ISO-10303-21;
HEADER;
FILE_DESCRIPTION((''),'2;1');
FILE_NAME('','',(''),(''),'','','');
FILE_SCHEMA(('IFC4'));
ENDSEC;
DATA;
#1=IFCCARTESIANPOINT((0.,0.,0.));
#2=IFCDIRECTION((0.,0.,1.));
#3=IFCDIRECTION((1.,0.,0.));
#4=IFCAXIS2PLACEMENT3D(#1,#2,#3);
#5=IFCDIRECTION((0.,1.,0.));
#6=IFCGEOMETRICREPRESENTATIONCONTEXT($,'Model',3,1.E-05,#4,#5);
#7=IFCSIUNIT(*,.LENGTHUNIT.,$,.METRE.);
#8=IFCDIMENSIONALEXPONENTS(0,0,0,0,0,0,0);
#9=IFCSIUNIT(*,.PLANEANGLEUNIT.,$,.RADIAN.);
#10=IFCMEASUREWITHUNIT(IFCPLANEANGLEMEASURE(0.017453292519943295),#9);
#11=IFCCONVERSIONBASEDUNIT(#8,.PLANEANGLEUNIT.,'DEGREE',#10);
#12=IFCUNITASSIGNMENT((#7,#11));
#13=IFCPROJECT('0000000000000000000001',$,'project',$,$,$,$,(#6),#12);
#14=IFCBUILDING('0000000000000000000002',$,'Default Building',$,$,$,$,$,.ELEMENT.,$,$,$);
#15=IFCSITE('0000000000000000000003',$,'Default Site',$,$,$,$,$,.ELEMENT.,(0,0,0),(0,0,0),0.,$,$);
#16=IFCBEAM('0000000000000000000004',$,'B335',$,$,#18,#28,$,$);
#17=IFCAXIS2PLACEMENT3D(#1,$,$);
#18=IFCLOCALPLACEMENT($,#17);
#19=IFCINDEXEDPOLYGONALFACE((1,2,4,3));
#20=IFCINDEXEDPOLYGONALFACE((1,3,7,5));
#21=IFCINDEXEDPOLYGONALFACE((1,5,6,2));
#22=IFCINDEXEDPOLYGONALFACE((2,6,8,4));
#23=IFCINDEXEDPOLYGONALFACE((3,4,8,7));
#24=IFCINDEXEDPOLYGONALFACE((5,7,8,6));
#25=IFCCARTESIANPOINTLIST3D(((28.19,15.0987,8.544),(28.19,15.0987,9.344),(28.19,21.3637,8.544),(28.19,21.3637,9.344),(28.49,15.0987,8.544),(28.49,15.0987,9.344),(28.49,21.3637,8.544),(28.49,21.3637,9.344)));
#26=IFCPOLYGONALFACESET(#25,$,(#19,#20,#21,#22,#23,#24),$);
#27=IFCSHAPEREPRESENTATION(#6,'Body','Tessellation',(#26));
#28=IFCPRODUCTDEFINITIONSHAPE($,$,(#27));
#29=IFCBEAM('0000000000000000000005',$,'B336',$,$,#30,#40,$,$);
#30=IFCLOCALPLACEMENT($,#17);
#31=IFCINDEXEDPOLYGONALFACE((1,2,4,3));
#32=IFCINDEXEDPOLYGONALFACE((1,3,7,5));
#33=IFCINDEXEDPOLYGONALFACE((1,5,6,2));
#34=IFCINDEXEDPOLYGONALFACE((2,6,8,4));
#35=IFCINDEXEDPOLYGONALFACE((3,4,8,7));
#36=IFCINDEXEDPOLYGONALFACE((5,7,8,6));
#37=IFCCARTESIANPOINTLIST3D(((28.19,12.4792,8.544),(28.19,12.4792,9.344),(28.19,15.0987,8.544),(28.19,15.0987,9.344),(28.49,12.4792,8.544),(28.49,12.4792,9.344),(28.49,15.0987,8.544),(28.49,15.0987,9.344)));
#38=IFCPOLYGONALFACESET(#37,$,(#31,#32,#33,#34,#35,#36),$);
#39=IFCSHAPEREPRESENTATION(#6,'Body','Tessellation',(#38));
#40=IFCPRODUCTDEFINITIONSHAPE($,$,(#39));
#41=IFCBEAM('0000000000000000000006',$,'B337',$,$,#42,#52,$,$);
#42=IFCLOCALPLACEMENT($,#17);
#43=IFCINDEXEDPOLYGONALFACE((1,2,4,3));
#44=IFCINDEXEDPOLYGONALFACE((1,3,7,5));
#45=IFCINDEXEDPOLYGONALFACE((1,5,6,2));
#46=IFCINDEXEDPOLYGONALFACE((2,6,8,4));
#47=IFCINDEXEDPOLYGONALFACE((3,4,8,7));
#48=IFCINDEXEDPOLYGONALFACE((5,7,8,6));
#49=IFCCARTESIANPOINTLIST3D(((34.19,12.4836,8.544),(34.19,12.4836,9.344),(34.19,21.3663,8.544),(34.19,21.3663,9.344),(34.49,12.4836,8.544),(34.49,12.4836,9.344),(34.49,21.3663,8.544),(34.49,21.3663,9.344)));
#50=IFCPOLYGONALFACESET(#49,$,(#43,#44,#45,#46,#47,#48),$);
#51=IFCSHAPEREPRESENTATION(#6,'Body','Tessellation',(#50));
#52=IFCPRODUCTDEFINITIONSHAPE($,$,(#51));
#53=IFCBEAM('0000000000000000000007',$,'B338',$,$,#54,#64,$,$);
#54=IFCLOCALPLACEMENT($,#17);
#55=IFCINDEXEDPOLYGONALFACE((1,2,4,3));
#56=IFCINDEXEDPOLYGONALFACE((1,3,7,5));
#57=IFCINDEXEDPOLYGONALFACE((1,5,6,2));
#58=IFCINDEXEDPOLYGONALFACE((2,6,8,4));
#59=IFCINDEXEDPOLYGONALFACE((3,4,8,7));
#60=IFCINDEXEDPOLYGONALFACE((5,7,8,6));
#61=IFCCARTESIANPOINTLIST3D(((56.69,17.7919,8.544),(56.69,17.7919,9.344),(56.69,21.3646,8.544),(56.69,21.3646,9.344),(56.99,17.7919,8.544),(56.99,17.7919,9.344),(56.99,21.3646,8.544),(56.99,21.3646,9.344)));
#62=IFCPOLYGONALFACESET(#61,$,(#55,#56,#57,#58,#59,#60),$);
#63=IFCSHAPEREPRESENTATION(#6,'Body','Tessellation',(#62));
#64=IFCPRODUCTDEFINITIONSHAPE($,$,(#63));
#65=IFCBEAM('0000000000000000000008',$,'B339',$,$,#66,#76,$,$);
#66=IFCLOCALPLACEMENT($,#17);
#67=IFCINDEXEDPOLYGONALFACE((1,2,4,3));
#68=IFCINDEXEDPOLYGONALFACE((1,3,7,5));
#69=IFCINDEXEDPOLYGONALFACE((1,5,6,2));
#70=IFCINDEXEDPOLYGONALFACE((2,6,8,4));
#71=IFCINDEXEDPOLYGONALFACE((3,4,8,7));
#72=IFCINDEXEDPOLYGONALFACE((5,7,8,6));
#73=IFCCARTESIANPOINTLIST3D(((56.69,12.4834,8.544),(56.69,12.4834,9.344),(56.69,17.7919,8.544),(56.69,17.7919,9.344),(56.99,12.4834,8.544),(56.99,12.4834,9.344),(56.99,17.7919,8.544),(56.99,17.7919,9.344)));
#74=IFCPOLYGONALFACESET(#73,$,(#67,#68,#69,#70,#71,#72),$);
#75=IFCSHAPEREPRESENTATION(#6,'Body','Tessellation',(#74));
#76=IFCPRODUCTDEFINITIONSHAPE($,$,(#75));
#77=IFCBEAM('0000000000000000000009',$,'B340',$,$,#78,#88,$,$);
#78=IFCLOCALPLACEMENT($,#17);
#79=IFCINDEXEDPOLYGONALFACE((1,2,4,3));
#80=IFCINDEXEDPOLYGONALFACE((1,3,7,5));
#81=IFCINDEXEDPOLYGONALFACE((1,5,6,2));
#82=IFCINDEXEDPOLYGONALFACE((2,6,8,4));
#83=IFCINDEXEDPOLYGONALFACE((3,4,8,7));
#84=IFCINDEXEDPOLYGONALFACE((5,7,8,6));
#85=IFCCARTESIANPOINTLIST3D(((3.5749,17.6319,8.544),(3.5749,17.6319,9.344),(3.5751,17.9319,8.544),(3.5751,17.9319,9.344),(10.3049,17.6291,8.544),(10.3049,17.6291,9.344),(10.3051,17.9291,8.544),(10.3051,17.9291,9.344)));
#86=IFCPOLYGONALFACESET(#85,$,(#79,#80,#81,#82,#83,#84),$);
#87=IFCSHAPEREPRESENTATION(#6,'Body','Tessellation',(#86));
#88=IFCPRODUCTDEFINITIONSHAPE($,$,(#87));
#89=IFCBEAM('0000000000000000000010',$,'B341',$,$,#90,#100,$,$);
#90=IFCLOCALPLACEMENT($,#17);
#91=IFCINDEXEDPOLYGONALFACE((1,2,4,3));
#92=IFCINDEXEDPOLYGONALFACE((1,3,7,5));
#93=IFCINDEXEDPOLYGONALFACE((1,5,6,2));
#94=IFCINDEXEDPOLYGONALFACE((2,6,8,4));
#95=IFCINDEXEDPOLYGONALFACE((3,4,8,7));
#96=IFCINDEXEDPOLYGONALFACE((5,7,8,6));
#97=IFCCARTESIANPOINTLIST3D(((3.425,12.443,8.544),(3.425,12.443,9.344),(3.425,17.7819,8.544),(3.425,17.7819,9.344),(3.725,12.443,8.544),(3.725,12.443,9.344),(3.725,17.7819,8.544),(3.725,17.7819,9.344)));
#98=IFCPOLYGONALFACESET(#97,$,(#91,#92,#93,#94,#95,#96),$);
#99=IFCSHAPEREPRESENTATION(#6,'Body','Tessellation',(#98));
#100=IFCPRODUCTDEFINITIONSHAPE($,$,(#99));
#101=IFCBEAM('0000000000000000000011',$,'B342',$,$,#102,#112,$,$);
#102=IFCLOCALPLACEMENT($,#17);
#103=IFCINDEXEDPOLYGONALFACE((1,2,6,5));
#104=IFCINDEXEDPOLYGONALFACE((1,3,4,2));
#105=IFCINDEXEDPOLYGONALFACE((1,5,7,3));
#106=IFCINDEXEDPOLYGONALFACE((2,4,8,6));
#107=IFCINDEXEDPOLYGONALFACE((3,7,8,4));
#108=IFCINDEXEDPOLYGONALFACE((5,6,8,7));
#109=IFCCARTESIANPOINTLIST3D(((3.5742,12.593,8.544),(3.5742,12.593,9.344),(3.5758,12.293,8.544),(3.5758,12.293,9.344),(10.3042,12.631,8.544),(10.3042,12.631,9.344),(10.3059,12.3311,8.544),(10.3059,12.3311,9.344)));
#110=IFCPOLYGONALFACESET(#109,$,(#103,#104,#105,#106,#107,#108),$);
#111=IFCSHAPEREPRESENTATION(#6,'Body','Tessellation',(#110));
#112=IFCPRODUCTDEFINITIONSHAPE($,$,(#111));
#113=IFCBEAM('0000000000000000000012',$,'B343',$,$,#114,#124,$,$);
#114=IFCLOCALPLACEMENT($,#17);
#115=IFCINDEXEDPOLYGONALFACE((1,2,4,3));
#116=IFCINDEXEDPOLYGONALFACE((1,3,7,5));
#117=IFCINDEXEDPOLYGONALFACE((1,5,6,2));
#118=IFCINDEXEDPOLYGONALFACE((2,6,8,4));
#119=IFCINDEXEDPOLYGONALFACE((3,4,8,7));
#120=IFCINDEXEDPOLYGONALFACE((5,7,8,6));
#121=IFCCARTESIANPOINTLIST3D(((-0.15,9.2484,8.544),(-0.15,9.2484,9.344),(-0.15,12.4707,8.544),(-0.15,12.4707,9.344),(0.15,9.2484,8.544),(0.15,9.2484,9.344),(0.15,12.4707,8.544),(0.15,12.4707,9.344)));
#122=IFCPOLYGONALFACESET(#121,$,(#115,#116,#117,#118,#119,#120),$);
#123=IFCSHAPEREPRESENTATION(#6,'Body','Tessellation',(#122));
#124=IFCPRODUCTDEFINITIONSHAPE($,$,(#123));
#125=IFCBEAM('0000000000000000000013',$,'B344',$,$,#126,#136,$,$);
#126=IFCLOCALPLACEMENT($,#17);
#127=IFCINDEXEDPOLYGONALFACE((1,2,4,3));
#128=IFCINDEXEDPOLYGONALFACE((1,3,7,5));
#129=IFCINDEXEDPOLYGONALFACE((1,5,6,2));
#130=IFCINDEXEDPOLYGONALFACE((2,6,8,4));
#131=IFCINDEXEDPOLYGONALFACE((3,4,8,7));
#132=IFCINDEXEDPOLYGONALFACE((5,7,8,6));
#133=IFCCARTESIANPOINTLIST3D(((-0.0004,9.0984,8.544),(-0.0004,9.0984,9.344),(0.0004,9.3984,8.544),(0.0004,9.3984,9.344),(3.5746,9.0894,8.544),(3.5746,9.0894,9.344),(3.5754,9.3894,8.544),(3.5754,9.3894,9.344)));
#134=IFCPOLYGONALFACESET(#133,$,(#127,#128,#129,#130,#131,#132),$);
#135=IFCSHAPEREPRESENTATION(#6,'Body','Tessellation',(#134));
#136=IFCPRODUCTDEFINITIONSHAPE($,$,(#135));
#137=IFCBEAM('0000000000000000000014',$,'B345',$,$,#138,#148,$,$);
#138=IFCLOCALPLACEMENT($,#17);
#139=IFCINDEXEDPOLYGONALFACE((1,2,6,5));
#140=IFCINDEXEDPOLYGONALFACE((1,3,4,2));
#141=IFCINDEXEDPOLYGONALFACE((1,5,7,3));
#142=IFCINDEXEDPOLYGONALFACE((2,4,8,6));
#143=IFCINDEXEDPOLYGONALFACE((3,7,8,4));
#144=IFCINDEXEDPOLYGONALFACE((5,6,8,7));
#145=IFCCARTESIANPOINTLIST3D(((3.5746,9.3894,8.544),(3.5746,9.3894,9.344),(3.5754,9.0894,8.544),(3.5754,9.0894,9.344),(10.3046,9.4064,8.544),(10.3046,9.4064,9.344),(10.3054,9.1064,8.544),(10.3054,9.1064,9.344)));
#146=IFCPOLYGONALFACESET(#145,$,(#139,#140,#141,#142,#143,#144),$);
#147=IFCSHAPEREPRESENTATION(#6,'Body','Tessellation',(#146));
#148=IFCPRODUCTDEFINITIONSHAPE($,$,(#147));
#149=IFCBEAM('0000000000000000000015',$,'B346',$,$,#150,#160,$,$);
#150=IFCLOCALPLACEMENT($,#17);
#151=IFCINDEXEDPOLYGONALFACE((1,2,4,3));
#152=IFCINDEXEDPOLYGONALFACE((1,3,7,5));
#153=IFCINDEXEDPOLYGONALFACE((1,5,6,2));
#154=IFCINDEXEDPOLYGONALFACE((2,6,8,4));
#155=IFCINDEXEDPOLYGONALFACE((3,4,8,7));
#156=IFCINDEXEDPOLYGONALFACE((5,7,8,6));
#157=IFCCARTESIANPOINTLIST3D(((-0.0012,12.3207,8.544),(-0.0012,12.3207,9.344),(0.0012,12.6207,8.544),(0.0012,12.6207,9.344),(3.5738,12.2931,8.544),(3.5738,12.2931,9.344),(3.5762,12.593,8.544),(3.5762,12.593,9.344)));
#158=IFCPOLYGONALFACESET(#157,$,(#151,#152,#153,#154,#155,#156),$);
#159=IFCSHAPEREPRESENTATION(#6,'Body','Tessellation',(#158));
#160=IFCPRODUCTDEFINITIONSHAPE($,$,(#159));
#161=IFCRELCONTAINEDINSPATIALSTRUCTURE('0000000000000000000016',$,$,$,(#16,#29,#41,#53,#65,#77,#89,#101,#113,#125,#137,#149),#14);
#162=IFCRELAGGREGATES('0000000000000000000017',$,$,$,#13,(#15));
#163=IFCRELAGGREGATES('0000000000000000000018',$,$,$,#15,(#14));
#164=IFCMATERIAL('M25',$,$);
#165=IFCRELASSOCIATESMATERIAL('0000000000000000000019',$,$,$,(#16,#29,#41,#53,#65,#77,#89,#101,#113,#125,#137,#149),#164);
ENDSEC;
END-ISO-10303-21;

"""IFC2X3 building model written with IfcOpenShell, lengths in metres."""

from ifc_helpers import new_model, entity, si_unit, converted_unit, direction, frame, frame_2d, origin_with_axes, place, context, project, spatial, rectangle, extrude, material, element, save


model = new_model("IFC2X3")

# Units and contexts
model_context = context("Model", 3, precision=1e-05, world=origin_with_axes(), true_north=direction((0.0, 1.0, 0.0)))
ifc_project = project(units=[si_unit("LENGTHUNIT", "METRE"), converted_unit("PLANEANGLEUNIT", "DEGREE", entity("IfcPlaneAngleMeasure", 0.017453292519943295), si_unit("PLANEANGLEUNIT", "RADIAN"), dimensions=[0, 0, 0, 0, 0, 0, 0])], contexts=[model_context])

# Site, building
site = spatial("IfcSite", under=ifc_project, Name="Default Site", CompositionType="ELEMENT", RefLatitude=(0, 0, 0), RefLongitude=(0, 0, 0), RefElevation=0.0)
building = spatial("IfcBuilding", under=site, Name="Default Building", CompositionType="ELEMENT")

# Beams
ifc_material = material(Name="M25")
placement = place(None, origin_with_axes())
element("IfcBeam", 1, at=placement, inside=building, material=ifc_material, Name="B335", context=model_context, shape_type="SweptSolid", body=[
    extrude(rectangle(XDim=0.3, YDim=0.8, at=frame_2d((0.0, 0.0), x_axis=(0.0, 1.0, 0.0))), frame((28.34, 21.3637, 8.944), z_axis=(0.0, -1.0, 0.0), x_axis=(0.0, 0.0, -1.0)), (0.0, 0.0, 1.0), 6.265),
])
element("IfcBeam", 2, at=placement, inside=building, material=ifc_material, Name="B336", context=model_context, shape_type="SweptSolid", body=[
    extrude(rectangle(XDim=0.3, YDim=0.8, at=frame_2d((0.0, 0.0), x_axis=(0.0, 1.0, 0.0))), frame((28.34, 15.0987, 8.944), z_axis=(0.0, -1.0, 0.0), x_axis=(0.0, 0.0, -1.0)), (0.0, 0.0, 1.0), 2.6195),
])
element("IfcBeam", 3, at=placement, inside=building, material=ifc_material, Name="B337", context=model_context, shape_type="SweptSolid", body=[
    extrude(rectangle(XDim=0.3, YDim=0.8, at=frame_2d((0.0, 0.0), x_axis=(0.0, 1.0, 0.0))), frame((34.34, 12.4836, 8.944), z_axis=(0.0, 1.0, 0.0), x_axis=(0.0, 0.0, -1.0)), (0.0, 0.0, 1.0), 8.8827),
])
element("IfcBeam", 4, at=placement, inside=building, material=ifc_material, Name="B338", context=model_context, shape_type="SweptSolid", body=[
    extrude(rectangle(XDim=0.3, YDim=0.8, at=frame_2d((0.0, 0.0), x_axis=(0.0, 1.0, 0.0))), frame((56.84, 17.7919, 8.944), z_axis=(0.0, 1.0, 0.0), x_axis=(0.0, 0.0, -1.0)), (0.0, 0.0, 1.0), 3.5727),
])
element("IfcBeam", 5, at=placement, inside=building, material=ifc_material, Name="B339", context=model_context, shape_type="SweptSolid", body=[
    extrude(rectangle(XDim=0.3, YDim=0.8, at=frame_2d((0.0, 0.0), x_axis=(0.0, 1.0, 0.0))), frame((56.84, 12.4834, 8.944), z_axis=(0.0, 1.0, 0.0), x_axis=(0.0, 0.0, -1.0)), (0.0, 0.0, 1.0), 5.3085),
])
element("IfcBeam", 6, at=placement, inside=building, material=ifc_material, Name="B340", context=model_context, shape_type="SweptSolid", body=[
    extrude(rectangle(XDim=0.3, YDim=0.8, at=frame_2d((0.0, 0.0), x_axis=(0.0, 1.0, 0.0))), frame((10.305, 17.7791, 8.944), z_axis=(-1.0, 0.000419, 0.0), x_axis=(0.0, 0.0, -1.0)), (0.0, 0.0, 1.0), 6.73),
])
element("IfcBeam", 7, at=placement, inside=building, material=ifc_material, Name="B341", context=model_context, shape_type="SweptSolid", body=[
    extrude(rectangle(XDim=0.3, YDim=0.8, at=frame_2d((0.0, 0.0), x_axis=(0.0, 1.0, 0.0))), frame((3.575, 12.443, 8.944), z_axis=(0.0, 1.0, 0.0), x_axis=(0.0, 0.0, -1.0)), (0.0, 0.0, 1.0), 5.3389),
])
element("IfcBeam", 8, at=placement, inside=building, material=ifc_material, Name="B342", context=model_context, shape_type="SweptSolid", body=[
    extrude(rectangle(XDim=0.3, YDim=0.8, at=frame_2d((0.0, 0.0), x_axis=(0.0, 1.0, 0.0))), frame((3.575, 12.443, 8.944), z_axis=(0.999984, 0.005654, 0.0), x_axis=(0.0, 0.0, -1.0)), (0.0, 0.0, 1.0), 6.7301),
])
element("IfcBeam", 9, at=placement, inside=building, material=ifc_material, Name="B343", context=model_context, shape_type="SweptSolid", body=[
    extrude(rectangle(XDim=0.3, YDim=0.8, at=frame_2d((0.0, 0.0), x_axis=(0.0, 1.0, 0.0))), frame((0.0, 9.2484, 8.944), z_axis=(0.0, 1.0, 0.0), x_axis=(0.0, 0.0, -1.0)), (0.0, 0.0, 1.0), 3.2223),
])
element("IfcBeam", 10, at=placement, inside=building, material=ifc_material, Name="B344", context=model_context, shape_type="SweptSolid", body=[
    extrude(rectangle(XDim=0.3, YDim=0.8, at=frame_2d((0.0, 0.0), x_axis=(0.0, 1.0, 0.0))), frame((0.0, 9.2484, 8.944), z_axis=(0.999997, -0.002499, 0.0), x_axis=(0.0, 0.0, -1.0)), (0.0, 0.0, 1.0), 3.575),
])
element("IfcBeam", 11, at=placement, inside=building, material=ifc_material, Name="B345", context=model_context, shape_type="SweptSolid", body=[
    extrude(rectangle(XDim=0.3, YDim=0.8, at=frame_2d((0.0, 0.0), x_axis=(0.0, 1.0, 0.0))), frame((3.575, 9.2394, 8.944), z_axis=(0.999997, 0.002522, 0.0), x_axis=(0.0, 0.0, -1.0)), (0.0, 0.0, 1.0), 6.73),
])
element("IfcBeam", 12, at=placement, inside=building, material=ifc_material, Name="B346", context=model_context, shape_type="SweptSolid", body=[
    extrude(rectangle(XDim=0.3, YDim=0.8, at=frame_2d((0.0, 0.0), x_axis=(0.0, 1.0, 0.0))), frame((0.0, 12.4707, 8.944), z_axis=(0.99997, -0.007734, 0.0), x_axis=(0.0, 0.0, -1.0)), (0.0, 0.0, 1.0), 3.5751),
])

save(model, "model.ifc")
